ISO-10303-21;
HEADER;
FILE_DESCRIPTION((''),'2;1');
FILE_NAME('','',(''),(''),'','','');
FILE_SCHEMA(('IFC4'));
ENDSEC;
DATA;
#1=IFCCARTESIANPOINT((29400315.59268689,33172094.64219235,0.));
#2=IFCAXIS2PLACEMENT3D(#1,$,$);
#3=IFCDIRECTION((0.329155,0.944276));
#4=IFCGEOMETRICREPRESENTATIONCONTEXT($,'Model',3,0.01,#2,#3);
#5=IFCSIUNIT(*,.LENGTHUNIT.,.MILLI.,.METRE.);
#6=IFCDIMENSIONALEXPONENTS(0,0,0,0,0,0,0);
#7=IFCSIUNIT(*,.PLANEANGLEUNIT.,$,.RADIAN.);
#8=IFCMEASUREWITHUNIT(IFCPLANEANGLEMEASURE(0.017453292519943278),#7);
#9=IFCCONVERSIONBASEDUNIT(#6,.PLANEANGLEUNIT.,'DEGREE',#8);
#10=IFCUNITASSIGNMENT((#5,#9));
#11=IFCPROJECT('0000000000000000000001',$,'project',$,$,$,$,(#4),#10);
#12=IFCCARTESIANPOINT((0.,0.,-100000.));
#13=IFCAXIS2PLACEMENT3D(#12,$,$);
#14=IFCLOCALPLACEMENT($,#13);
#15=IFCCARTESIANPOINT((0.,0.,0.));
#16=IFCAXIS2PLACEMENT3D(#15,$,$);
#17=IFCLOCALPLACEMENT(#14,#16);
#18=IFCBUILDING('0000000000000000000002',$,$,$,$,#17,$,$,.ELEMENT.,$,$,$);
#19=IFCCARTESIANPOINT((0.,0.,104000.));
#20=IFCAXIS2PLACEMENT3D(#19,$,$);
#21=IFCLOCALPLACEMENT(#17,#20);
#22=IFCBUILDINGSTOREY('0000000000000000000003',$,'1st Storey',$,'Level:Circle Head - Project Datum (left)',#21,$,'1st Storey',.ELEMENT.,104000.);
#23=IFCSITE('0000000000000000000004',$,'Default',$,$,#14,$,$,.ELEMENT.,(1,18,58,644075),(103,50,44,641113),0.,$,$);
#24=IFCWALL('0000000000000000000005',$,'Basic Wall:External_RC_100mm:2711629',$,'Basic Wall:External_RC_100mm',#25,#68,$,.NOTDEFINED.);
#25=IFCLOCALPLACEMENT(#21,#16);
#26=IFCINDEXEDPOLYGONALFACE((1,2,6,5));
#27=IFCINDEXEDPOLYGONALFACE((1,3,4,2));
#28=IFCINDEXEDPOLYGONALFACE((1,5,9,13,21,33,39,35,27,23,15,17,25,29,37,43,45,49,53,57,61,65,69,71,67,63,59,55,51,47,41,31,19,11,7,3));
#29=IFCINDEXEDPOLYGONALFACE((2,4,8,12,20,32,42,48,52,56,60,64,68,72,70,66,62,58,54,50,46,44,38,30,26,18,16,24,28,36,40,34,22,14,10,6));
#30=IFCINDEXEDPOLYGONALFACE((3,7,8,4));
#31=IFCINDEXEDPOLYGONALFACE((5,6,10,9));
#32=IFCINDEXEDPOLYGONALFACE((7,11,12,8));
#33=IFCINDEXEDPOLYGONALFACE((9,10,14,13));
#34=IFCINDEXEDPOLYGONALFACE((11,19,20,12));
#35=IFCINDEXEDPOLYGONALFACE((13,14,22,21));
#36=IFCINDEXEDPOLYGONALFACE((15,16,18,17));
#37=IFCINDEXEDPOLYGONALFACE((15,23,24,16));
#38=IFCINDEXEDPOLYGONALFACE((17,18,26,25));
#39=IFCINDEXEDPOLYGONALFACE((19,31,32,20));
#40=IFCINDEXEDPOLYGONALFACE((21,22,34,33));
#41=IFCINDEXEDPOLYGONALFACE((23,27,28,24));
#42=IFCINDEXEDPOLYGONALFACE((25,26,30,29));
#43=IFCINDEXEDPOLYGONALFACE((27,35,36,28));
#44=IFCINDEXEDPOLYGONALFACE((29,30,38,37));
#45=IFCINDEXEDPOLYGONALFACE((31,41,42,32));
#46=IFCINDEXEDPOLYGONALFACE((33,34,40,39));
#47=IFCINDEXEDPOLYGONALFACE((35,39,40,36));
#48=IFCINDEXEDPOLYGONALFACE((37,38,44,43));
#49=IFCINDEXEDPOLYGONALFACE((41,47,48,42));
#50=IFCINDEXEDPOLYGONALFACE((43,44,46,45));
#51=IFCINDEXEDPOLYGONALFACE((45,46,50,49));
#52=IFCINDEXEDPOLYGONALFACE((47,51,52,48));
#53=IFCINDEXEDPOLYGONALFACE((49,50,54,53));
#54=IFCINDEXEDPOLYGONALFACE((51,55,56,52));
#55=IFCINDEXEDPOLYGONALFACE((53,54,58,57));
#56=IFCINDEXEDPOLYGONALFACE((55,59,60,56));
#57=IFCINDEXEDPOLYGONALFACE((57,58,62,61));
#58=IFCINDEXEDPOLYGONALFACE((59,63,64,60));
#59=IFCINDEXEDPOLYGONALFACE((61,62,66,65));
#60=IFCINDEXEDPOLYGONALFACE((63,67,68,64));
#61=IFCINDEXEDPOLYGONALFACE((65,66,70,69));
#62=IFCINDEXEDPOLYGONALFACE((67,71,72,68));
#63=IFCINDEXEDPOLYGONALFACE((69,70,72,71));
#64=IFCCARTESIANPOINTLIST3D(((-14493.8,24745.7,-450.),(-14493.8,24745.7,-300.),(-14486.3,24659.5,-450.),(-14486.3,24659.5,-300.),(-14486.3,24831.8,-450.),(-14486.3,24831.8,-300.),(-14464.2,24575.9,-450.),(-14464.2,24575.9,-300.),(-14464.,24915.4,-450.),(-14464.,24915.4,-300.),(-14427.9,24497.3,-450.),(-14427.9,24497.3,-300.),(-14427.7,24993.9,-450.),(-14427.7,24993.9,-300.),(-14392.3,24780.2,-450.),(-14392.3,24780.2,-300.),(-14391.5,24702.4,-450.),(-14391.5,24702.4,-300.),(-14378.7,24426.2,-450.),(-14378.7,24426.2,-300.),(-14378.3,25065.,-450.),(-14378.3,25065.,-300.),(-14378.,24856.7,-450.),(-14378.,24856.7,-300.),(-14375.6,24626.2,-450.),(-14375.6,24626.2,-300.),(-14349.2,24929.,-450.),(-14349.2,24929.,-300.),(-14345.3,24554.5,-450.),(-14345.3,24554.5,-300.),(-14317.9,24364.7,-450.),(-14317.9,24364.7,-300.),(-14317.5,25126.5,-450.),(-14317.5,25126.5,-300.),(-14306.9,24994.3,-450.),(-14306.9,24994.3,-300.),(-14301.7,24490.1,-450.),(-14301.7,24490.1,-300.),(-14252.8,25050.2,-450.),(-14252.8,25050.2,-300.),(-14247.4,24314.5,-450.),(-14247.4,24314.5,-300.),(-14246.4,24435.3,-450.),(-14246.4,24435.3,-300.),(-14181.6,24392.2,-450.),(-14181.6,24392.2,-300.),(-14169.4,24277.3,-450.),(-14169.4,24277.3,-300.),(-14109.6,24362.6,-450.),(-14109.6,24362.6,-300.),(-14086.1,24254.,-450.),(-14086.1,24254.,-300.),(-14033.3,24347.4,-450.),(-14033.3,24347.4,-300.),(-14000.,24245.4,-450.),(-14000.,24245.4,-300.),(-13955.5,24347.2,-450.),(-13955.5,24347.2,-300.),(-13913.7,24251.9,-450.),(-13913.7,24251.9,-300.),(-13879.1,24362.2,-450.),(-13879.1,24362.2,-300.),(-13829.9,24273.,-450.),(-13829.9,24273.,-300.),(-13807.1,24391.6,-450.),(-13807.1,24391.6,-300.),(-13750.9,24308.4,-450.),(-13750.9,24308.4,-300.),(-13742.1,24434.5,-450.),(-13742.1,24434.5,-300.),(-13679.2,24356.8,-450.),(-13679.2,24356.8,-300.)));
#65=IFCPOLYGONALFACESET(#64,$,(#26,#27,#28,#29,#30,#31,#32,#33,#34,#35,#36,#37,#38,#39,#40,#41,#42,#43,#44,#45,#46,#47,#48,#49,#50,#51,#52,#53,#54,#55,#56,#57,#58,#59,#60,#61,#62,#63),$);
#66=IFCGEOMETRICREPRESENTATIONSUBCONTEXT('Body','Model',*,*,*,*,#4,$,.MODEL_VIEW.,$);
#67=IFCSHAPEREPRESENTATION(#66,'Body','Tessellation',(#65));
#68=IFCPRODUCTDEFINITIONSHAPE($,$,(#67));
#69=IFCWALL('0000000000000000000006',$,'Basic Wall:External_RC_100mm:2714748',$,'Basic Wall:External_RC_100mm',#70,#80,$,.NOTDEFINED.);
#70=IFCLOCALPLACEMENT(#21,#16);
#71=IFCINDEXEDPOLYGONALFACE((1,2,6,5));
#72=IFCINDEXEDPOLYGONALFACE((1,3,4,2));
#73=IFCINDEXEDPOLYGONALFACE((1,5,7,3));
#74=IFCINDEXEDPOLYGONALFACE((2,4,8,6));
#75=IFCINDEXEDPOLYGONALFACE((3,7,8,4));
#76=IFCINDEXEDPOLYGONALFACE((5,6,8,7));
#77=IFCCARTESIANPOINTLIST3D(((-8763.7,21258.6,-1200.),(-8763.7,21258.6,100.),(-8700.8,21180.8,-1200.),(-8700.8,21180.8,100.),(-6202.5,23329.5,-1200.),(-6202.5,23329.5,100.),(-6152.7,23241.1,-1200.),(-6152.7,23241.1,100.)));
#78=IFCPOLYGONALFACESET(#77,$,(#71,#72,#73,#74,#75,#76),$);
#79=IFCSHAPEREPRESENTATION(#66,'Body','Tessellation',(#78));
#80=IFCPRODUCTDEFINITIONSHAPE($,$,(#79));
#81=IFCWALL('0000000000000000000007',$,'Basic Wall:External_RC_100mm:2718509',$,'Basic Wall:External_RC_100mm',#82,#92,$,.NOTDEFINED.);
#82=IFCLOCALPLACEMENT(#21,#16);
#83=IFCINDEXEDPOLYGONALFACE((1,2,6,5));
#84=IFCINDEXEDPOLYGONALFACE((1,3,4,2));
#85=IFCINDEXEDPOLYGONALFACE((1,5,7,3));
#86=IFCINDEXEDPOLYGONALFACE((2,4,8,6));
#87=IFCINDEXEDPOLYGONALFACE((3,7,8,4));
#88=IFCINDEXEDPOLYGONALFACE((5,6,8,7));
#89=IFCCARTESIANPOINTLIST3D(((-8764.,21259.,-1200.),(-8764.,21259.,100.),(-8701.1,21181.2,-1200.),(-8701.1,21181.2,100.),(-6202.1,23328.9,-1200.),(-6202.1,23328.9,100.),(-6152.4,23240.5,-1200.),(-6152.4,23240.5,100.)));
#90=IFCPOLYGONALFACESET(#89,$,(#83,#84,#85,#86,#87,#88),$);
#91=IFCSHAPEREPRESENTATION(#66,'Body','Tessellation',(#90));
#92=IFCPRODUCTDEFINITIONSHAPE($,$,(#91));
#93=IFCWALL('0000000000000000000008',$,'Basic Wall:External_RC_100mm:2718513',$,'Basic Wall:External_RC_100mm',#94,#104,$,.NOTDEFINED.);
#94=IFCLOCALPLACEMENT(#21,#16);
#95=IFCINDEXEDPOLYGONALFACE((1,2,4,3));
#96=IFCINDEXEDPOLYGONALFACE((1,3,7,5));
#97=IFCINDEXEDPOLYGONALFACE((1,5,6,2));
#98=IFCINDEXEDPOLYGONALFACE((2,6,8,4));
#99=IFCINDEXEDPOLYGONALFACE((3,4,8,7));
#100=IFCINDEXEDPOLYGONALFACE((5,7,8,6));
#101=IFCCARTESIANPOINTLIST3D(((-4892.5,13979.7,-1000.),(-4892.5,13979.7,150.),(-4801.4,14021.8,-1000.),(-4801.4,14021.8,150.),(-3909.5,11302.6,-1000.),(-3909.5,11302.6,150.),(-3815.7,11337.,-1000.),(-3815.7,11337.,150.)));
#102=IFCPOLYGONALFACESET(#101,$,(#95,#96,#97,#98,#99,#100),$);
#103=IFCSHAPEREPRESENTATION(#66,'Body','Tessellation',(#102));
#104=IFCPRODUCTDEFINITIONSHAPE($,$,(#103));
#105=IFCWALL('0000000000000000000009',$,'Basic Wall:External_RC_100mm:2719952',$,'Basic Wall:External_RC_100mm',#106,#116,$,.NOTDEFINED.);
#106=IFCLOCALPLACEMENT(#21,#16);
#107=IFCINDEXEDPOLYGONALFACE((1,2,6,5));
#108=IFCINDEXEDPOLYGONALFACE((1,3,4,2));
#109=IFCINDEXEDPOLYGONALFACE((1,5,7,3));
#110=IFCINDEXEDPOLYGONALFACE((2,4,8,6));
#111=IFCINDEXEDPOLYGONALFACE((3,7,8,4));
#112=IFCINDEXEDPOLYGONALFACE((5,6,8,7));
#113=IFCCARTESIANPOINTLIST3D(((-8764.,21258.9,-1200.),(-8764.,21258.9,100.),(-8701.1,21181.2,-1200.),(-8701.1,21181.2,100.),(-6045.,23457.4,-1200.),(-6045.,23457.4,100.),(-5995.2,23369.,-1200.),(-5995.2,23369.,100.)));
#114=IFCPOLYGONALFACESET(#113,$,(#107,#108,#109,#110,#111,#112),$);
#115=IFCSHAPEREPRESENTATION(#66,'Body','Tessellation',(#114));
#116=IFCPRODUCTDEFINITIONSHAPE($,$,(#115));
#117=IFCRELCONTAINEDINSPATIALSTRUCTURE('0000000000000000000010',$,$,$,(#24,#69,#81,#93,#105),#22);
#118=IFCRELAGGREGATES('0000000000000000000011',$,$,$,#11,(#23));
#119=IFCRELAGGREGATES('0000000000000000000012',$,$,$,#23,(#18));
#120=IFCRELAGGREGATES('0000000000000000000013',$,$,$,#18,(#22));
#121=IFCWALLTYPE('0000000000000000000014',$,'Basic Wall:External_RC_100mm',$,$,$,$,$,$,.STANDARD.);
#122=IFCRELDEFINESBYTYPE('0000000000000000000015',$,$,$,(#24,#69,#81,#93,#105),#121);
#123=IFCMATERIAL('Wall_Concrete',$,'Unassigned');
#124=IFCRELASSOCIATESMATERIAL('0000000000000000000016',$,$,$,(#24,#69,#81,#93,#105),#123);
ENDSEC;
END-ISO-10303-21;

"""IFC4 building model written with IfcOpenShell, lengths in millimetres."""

from ifc_helpers import new_model, entity, si_unit, converted_unit, direction, frame, origin, place, context, subcontext, project, spatial, line, arc, indexed_curve, outline, extrude, material, type_object, element, save


model = new_model("IFC4")

# Units and contexts
model_context = context("Model", 3, precision=0.01, world=frame((29400315.59268689, 33172094.64219235, 0.0)), true_north=direction((0.329155, 0.944276)))
body_context = subcontext(model_context, "Body", "Model", "MODEL_VIEW")
ifc_project = project(units=[si_unit("LENGTHUNIT", "METRE", prefix="MILLI"), converted_unit("PLANEANGLEUNIT", "DEGREE", entity("IfcPlaneAngleMeasure", 0.017453292519943278), si_unit("PLANEANGLEUNIT", "RADIAN"), dimensions=[0, 0, 0, 0, 0, 0, 0])], contexts=[model_context])

# Site, building, storey
site_placement = place(None, frame((0.0, 0.0, -100000.0)))
site = spatial("IfcSite", under=ifc_project, at=site_placement, Name="Default", CompositionType="ELEMENT", RefLatitude=(1, 18, 58, 644075), RefLongitude=(103, 50, 44, 641113), RefElevation=0.0)
building_placement = place(site_placement, origin())
building = spatial("IfcBuilding", under=site, at=building_placement, CompositionType="ELEMENT")
storey_placement = place(building_placement, frame((0.0, 0.0, 104000.0)))
storey = spatial("IfcBuildingStorey", under=building, at=storey_placement, Name="1st Storey", ObjectType="Level:Circle Head - Project Datum (left)", LongName="1st Storey", CompositionType="ELEMENT", Elevation=104000.0)

# Walls
ifc_material_1 = material(Name="Wall_Concrete", Category="Unassigned")
wall_type_1 = type_object("IfcWallType", Name="Basic Wall:External_RC_100mm", PredefinedType="STANDARD")
wall_1_placement = place(storey_placement, frame((-14285.1, 25088.3, -450.0)))
element("IfcWall", 1, at=wall_1_placement, inside=storey, type_object=wall_type_1, material=ifc_material_1, Name="Basic Wall:External_RC_100mm:2711629", ObjectType="Basic Wall:External_RC_100mm", PredefinedType="NOTDEFINED", context=body_context, shape_type="SweptSolid", body=[
    extrude(outline(indexed_curve([(543.0, -653.9), (-16.5, -598.3), (32.4, -38.1), (-32.4, 38.1), (-93.5, -662.1), (605.9, -731.6)], segments=[arc(1, 2, 3), line(3, 4), arc(4, 5, 6), line(6, 1)], self_intersect=False)), origin(), (0.0, 0.0, 1.0), 150.0),
])
wall_2_placement = place(storey_placement, frame((-8732.3, 21219.7, -1200.0), z_axis=(0.0, 0.0, 1.0), x_axis=(0.777618, 0.628737, 0.0)))
element("IfcWall", 2, at=wall_2_placement, inside=storey, type_object=wall_type_1, material=ifc_material_1, Name="Basic Wall:External_RC_100mm:2714748", ObjectType="Basic Wall:External_RC_100mm", PredefinedType="NOTDEFINED", context=body_context, shape_type="SweptSolid", body=[
    extrude(outline(indexed_curve([(3276.8, -50.0), (3293.7, 50.0), (0.0, 50.0), (0.0, -50.0), (3276.8, -50.0)], self_intersect=False)), origin(), (0.0, 0.0, 1.0), 1300.0),
])
wall_3_placement = place(storey_placement, frame((-8732.5, 21220.1, -1200.0), z_axis=(0.0, 0.0, 1.0), x_axis=(0.777829, 0.628476, 0.0)))
element("IfcWall", 3, at=wall_3_placement, inside=storey, type_object=wall_type_1, material=ifc_material_1, Name="Basic Wall:External_RC_100mm:2718509", ObjectType="Basic Wall:External_RC_100mm", PredefinedType="NOTDEFINED", context=body_context, shape_type="SweptSolid", body=[
    extrude(outline(indexed_curve([(3276.7, -50.0), (3293.6, 50.0), (0.0, 50.0), (0.0, -50.0), (3276.7, -50.0)], self_intersect=False)), origin(), (0.0, 0.0, 1.0), 1300.0),
])
wall_4_placement = place(storey_placement, frame((-4848.3, 14004.5, -1000.0), z_axis=(0.0, 0.0, 1.0), x_axis=(0.344668, -0.938725, 0.0)))
element("IfcWall", 4, at=wall_4_placement, inside=storey, type_object=wall_type_1, material=ifc_material_1, Name="Basic Wall:External_RC_100mm:2718513", ObjectType="Basic Wall:External_RC_100mm", PredefinedType="NOTDEFINED", context=body_context, shape_type="SweptSolid", body=[
    extrude(outline(indexed_curve([(2860.0, -50.0), (2860.0, 50.0), (0.0, 50.0), (8.1, -50.0), (2860.0, -50.0)], self_intersect=False)), origin(), (0.0, 0.0, 1.0), 1150.0),
])
wall_5_placement = place(storey_placement, frame((-8732.5, 21220.1, -1200.0), z_axis=(0.0, 0.0, 1.0), x_axis=(0.777618, 0.628737, 0.0)))
element("IfcWall", 5, at=wall_5_placement, inside=storey, type_object=wall_type_1, material=ifc_material_1, Name="Basic Wall:External_RC_100mm:2719952", ObjectType="Basic Wall:External_RC_100mm", PredefinedType="NOTDEFINED", context=body_context, shape_type="SweptSolid", body=[
    extrude(outline(indexed_curve([(3479.7, -50.0), (3496.6, 50.0), (0.0, 50.0), (0.0, -50.0), (3479.7, -50.0)], self_intersect=False)), origin(), (0.0, 0.0, 1.0), 1300.0),
])

save(model, "model.ifc")
